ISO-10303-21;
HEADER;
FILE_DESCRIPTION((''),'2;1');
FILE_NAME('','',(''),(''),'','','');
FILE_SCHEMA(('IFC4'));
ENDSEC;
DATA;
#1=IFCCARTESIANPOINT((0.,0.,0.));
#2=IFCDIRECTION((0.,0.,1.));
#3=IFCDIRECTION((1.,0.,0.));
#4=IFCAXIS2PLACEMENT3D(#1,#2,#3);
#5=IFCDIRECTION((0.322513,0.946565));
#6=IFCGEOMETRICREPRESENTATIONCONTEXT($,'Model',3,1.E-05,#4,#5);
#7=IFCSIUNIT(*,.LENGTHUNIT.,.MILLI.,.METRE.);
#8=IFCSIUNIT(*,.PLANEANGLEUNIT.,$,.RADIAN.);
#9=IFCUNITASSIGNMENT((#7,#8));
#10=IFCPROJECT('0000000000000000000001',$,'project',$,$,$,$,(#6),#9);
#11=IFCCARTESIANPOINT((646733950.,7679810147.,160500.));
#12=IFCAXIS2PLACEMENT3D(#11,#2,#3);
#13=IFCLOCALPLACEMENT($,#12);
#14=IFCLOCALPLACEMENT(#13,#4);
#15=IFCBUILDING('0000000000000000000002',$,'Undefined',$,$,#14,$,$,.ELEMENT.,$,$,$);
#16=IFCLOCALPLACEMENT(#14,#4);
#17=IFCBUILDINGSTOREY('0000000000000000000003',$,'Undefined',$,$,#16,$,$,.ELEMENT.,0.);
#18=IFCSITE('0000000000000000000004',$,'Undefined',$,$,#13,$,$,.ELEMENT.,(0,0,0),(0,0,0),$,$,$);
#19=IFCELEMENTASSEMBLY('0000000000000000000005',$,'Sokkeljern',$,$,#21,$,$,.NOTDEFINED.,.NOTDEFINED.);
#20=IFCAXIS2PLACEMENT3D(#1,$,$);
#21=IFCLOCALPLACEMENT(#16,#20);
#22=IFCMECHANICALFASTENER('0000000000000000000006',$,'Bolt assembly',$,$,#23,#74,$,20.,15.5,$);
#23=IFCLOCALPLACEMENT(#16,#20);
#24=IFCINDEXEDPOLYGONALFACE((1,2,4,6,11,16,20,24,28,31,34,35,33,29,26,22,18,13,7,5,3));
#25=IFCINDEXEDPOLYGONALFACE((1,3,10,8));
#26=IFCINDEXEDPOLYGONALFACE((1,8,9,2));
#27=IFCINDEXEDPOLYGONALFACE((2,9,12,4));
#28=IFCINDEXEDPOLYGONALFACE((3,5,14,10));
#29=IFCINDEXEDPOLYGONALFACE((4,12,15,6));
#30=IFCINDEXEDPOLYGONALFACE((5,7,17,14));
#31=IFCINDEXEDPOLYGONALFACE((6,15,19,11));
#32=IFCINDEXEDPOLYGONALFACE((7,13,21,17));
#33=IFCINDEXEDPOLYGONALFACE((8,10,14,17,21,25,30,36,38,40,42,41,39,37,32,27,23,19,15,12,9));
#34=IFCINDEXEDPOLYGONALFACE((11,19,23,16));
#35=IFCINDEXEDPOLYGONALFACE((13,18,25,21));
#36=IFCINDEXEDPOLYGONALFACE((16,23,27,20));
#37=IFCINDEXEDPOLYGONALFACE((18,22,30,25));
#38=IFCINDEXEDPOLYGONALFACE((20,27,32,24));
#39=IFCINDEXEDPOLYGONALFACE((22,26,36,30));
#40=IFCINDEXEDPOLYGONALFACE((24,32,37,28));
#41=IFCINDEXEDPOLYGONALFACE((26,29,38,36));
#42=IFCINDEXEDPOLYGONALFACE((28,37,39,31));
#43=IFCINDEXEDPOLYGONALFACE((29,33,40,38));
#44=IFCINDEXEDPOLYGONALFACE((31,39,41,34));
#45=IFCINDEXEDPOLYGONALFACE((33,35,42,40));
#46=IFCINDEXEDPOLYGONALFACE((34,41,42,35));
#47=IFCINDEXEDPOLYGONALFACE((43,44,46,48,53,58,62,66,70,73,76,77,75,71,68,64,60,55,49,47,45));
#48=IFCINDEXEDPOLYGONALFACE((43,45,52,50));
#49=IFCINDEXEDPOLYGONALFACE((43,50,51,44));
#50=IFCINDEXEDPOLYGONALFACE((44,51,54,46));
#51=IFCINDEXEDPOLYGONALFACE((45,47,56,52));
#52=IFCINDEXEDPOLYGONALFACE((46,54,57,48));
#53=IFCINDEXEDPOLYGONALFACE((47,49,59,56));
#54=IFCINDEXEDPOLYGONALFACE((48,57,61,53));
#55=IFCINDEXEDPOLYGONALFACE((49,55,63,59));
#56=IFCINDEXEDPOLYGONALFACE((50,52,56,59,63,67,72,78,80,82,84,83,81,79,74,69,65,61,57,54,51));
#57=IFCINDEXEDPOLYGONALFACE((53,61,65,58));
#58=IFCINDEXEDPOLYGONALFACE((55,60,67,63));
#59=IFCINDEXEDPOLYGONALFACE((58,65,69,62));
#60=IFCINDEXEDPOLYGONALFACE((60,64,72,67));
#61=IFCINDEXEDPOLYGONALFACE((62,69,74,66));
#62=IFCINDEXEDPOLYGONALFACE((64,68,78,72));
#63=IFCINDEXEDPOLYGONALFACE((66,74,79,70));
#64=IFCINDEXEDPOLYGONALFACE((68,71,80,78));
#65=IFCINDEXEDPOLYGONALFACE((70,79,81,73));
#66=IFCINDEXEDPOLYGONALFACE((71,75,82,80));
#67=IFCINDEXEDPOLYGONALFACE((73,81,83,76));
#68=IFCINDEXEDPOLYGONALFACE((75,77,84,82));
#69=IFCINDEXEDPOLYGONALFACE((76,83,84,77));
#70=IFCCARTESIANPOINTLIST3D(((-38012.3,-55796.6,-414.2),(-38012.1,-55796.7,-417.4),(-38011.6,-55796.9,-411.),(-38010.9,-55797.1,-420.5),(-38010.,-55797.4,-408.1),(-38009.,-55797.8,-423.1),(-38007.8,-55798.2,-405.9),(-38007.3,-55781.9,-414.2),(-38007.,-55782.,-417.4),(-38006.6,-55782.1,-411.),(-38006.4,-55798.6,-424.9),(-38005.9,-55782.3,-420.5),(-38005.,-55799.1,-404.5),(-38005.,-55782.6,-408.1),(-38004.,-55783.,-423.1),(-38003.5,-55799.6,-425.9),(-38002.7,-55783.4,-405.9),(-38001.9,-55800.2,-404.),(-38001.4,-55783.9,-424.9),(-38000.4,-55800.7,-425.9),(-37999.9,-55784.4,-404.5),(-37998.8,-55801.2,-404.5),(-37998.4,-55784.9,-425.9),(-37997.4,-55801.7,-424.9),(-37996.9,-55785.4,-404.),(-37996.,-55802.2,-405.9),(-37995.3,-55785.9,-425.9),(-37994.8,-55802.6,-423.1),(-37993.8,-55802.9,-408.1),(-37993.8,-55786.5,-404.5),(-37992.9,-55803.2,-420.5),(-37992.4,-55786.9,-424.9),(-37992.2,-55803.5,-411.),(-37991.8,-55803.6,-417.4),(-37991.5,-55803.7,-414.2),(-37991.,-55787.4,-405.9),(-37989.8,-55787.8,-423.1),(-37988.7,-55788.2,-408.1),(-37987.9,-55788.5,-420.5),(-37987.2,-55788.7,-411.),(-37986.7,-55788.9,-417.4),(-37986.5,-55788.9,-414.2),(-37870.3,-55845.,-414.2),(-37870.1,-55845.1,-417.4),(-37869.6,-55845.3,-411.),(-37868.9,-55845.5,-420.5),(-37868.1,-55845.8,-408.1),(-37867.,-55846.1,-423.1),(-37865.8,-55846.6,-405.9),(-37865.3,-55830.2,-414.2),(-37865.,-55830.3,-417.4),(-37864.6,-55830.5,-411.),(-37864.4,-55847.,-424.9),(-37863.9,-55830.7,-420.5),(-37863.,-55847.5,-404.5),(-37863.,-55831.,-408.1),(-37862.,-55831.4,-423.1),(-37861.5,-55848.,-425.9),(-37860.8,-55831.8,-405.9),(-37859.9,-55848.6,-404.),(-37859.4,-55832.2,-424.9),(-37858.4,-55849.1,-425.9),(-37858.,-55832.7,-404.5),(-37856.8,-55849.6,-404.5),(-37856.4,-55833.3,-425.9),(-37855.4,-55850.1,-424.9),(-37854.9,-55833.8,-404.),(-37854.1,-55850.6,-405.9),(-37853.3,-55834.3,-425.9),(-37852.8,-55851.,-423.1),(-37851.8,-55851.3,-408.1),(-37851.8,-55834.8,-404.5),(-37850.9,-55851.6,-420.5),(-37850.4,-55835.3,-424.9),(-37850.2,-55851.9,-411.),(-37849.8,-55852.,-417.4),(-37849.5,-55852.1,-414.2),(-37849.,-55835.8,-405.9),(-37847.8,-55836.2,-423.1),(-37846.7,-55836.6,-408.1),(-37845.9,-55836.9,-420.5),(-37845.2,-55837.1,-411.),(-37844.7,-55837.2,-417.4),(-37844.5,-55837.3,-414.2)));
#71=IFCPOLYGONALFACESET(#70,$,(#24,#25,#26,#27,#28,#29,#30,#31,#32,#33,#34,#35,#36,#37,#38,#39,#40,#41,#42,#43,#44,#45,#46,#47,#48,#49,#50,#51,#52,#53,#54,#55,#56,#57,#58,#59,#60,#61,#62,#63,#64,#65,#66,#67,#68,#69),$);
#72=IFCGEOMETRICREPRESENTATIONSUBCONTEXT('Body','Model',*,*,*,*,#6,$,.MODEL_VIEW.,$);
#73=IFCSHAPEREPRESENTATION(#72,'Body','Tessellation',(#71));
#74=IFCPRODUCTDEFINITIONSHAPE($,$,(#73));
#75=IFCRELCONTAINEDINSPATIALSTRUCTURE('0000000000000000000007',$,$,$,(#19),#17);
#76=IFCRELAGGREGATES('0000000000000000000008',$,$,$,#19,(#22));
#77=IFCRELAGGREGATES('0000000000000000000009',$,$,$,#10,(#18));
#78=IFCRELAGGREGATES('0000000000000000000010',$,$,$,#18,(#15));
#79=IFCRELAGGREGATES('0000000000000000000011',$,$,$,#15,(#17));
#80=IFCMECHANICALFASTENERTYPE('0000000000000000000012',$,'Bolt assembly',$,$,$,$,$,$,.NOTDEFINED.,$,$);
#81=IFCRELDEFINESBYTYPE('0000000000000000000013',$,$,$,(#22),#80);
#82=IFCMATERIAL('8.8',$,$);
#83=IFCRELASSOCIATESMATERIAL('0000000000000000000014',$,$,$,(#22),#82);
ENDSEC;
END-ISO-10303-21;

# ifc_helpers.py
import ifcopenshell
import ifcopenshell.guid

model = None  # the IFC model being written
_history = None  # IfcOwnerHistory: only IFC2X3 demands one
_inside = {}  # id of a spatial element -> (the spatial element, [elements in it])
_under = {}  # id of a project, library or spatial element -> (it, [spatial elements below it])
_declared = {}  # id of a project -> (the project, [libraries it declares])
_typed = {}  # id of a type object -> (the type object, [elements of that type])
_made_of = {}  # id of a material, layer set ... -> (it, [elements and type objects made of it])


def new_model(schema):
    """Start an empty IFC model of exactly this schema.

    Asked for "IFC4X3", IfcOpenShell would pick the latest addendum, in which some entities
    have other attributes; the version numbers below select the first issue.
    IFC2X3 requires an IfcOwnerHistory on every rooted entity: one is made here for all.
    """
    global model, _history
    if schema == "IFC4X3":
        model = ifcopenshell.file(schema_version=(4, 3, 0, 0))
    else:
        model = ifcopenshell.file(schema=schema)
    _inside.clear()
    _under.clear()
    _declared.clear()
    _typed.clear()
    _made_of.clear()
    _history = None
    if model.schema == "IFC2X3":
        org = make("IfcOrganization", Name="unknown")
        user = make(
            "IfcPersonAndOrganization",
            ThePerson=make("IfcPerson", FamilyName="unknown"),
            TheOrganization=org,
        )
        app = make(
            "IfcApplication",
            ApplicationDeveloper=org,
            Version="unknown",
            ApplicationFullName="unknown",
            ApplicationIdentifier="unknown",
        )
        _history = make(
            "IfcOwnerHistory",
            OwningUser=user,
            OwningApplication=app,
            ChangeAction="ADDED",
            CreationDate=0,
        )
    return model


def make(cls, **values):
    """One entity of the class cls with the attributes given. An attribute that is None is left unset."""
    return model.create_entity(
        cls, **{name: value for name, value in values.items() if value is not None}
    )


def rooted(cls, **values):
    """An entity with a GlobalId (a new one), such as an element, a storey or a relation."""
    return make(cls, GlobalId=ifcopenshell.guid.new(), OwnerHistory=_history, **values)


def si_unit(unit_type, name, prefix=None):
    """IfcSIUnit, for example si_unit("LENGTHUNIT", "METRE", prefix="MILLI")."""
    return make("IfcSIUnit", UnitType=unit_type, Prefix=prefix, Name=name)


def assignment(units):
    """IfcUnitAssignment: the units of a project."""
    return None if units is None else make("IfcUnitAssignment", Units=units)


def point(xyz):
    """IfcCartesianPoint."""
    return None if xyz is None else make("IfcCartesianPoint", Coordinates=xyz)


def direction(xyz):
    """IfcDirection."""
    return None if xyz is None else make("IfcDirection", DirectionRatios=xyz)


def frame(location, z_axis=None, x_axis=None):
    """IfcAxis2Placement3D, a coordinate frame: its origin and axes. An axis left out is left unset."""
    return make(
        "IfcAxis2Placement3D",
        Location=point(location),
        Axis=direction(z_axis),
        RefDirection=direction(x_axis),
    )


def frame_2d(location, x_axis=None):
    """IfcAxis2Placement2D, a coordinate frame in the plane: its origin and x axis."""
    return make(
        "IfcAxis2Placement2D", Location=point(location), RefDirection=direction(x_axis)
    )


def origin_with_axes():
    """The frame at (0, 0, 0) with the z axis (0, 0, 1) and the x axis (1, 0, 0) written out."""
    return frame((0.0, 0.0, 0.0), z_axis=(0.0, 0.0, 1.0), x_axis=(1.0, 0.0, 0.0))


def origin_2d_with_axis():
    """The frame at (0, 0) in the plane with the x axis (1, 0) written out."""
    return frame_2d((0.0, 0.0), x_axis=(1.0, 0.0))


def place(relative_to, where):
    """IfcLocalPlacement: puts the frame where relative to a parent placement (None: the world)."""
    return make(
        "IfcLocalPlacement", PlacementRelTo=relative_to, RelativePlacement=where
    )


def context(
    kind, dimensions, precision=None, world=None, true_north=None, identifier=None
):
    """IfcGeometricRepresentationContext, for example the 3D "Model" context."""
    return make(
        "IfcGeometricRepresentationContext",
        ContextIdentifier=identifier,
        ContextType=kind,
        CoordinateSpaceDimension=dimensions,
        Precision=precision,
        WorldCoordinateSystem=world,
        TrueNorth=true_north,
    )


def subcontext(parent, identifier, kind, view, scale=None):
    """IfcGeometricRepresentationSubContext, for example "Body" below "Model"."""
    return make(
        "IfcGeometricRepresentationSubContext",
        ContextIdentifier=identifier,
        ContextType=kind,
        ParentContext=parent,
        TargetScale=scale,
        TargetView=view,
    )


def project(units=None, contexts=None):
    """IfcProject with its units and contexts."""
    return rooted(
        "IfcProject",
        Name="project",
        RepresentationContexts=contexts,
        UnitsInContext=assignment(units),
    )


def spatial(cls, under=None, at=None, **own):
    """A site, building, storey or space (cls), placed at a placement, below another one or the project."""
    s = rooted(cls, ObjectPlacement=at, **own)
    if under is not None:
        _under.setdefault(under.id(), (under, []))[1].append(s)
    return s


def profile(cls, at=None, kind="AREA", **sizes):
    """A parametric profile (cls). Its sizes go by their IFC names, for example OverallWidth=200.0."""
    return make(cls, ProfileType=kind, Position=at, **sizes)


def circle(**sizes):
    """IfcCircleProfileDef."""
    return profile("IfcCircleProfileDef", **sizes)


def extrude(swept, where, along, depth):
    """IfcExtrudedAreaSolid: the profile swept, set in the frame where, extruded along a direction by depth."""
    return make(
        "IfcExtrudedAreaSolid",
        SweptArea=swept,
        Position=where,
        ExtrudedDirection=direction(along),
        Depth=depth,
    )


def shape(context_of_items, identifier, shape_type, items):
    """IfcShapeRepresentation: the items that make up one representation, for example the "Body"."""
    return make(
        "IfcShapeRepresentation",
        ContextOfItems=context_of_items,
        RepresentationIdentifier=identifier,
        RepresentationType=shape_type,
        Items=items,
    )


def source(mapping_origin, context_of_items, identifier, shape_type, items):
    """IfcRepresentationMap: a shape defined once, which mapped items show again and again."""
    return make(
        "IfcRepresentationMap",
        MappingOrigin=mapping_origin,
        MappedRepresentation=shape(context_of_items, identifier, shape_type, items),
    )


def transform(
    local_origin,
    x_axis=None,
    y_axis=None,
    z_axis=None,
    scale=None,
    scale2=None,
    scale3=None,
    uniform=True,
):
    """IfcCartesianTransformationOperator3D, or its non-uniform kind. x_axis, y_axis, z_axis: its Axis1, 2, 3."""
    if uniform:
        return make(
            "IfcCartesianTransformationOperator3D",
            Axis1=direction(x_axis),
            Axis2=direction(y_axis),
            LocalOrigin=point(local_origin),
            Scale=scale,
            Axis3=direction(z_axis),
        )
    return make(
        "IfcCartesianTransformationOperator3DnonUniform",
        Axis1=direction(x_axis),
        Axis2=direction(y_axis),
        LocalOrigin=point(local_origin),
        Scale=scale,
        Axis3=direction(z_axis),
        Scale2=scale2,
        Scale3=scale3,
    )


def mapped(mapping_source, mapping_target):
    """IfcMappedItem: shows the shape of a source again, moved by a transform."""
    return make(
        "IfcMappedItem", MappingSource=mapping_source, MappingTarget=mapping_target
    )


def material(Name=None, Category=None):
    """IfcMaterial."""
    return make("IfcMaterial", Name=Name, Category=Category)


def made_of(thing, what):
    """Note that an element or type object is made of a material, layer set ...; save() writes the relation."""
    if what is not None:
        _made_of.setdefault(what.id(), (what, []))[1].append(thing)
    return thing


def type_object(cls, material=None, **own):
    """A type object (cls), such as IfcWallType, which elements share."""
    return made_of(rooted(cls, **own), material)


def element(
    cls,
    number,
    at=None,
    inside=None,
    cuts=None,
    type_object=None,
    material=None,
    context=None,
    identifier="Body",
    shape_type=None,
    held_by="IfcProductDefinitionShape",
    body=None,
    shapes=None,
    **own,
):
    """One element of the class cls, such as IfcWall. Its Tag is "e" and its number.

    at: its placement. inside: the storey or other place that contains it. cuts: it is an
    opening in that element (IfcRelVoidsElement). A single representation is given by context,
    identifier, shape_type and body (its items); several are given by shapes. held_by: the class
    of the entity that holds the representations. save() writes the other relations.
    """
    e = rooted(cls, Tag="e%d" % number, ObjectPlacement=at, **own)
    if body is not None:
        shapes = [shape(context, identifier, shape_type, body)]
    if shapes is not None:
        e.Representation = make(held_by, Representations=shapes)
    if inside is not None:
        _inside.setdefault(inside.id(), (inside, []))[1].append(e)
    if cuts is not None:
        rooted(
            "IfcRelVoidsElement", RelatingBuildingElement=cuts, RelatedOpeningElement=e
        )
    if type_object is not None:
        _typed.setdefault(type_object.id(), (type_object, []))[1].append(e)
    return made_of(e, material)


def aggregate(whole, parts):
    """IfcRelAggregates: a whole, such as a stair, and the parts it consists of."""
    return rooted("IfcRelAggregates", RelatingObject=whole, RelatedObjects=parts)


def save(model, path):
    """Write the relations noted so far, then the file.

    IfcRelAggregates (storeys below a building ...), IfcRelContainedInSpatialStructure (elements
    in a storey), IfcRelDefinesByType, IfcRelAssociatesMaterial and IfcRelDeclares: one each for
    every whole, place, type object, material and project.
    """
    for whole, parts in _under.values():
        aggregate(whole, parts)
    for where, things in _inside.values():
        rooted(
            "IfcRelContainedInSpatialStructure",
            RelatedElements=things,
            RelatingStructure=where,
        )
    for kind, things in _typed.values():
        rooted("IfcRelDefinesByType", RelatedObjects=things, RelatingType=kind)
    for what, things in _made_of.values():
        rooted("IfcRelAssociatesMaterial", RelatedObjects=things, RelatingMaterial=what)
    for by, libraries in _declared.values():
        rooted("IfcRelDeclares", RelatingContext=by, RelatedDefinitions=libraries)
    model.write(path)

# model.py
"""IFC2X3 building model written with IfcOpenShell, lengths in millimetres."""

from ifc_helpers import new_model, si_unit, direction, frame, origin_with_axes, origin_2d_with_axis, place, context, subcontext, project, spatial, circle, extrude, source, transform, mapped, material, type_object, element, aggregate, save


model = new_model("IFC2X3")

# Units and contexts
model_context = context("Model", 3, precision=1e-05, world=origin_with_axes(), true_north=direction((0.322513, 0.946565)))
body_context = subcontext(model_context, "Body", "Model", "MODEL_VIEW")
ifc_project = project(units=[si_unit("LENGTHUNIT", "METRE", prefix="MILLI"), si_unit("PLANEANGLEUNIT", "RADIAN")], contexts=[model_context])

# Site, building, storey
site_placement = place(None, frame((646733950.0, 7679810147.0, 160500.0), z_axis=(0.0, 0.0, 1.0), x_axis=(1.0, 0.0, 0.0)))
site = spatial("IfcSite", under=ifc_project, at=site_placement, Name="Undefined", CompositionType="ELEMENT", RefLatitude=(0, 0, 0), RefLongitude=(0, 0, 0))
building_placement = place(site_placement, origin_with_axes())
building = spatial("IfcBuilding", under=site, at=building_placement, Name="Undefined", CompositionType="ELEMENT")
storey_placement = place(building_placement, origin_with_axes())
storey = spatial("IfcBuildingStorey", under=building, at=storey_placement, Name="Undefined", CompositionType="ELEMENT", Elevation=0.0)

# Element assembly
assembly_1_placement = place(storey_placement, origin_with_axes())
assembly_1 = element("IfcElementAssembly", 1, at=assembly_1_placement, inside=storey, Name="Sokkeljern", AssemblyPlace="NOTDEFINED", PredefinedType="NOTDEFINED")

# Mechanical fastener
ifc_material_1 = material(Name="8.8")
mechanical_fastener_type = type_object("IfcMechanicalFastenerType", Name="Bolt assembly")
shared_shape_1 = source(origin_with_axes(), body_context, "Body", "SweptSolid", [
    extrude(circle(Radius=11.0, at=origin_2d_with_axis()), frame((0.0, 0.0, 0.0), z_axis=(0.0, 1.0, 0.0), x_axis=(1.0, 0.0, 0.0)), (0.0, 0.0, 1.0), 15.6),
])
mechanical_fastener_1_placement = place(assembly_1_placement, frame((-37925.9, -55809.6, -415.0), z_axis=(0.946565, -0.322513, 0.0), x_axis=(0.0, 0.0, 1.0)))
mechanical_fastener_1 = element("IfcMechanicalFastener", 2, at=mechanical_fastener_1_placement, type_object=mechanical_fastener_type, material=ifc_material_1, Name="Bolt assembly", NominalDiameter=20.0, NominalLength=15.5, context=body_context, shape_type="MappedRepresentation", body=[
    mapped(shared_shape_1, transform((0.0, 0.0, -75.0))),
    mapped(shared_shape_1, transform((0.0, 0.0, 75.0))),
])
aggregate(assembly_1, [mechanical_fastener_1])

save(model, "model.ifc")
